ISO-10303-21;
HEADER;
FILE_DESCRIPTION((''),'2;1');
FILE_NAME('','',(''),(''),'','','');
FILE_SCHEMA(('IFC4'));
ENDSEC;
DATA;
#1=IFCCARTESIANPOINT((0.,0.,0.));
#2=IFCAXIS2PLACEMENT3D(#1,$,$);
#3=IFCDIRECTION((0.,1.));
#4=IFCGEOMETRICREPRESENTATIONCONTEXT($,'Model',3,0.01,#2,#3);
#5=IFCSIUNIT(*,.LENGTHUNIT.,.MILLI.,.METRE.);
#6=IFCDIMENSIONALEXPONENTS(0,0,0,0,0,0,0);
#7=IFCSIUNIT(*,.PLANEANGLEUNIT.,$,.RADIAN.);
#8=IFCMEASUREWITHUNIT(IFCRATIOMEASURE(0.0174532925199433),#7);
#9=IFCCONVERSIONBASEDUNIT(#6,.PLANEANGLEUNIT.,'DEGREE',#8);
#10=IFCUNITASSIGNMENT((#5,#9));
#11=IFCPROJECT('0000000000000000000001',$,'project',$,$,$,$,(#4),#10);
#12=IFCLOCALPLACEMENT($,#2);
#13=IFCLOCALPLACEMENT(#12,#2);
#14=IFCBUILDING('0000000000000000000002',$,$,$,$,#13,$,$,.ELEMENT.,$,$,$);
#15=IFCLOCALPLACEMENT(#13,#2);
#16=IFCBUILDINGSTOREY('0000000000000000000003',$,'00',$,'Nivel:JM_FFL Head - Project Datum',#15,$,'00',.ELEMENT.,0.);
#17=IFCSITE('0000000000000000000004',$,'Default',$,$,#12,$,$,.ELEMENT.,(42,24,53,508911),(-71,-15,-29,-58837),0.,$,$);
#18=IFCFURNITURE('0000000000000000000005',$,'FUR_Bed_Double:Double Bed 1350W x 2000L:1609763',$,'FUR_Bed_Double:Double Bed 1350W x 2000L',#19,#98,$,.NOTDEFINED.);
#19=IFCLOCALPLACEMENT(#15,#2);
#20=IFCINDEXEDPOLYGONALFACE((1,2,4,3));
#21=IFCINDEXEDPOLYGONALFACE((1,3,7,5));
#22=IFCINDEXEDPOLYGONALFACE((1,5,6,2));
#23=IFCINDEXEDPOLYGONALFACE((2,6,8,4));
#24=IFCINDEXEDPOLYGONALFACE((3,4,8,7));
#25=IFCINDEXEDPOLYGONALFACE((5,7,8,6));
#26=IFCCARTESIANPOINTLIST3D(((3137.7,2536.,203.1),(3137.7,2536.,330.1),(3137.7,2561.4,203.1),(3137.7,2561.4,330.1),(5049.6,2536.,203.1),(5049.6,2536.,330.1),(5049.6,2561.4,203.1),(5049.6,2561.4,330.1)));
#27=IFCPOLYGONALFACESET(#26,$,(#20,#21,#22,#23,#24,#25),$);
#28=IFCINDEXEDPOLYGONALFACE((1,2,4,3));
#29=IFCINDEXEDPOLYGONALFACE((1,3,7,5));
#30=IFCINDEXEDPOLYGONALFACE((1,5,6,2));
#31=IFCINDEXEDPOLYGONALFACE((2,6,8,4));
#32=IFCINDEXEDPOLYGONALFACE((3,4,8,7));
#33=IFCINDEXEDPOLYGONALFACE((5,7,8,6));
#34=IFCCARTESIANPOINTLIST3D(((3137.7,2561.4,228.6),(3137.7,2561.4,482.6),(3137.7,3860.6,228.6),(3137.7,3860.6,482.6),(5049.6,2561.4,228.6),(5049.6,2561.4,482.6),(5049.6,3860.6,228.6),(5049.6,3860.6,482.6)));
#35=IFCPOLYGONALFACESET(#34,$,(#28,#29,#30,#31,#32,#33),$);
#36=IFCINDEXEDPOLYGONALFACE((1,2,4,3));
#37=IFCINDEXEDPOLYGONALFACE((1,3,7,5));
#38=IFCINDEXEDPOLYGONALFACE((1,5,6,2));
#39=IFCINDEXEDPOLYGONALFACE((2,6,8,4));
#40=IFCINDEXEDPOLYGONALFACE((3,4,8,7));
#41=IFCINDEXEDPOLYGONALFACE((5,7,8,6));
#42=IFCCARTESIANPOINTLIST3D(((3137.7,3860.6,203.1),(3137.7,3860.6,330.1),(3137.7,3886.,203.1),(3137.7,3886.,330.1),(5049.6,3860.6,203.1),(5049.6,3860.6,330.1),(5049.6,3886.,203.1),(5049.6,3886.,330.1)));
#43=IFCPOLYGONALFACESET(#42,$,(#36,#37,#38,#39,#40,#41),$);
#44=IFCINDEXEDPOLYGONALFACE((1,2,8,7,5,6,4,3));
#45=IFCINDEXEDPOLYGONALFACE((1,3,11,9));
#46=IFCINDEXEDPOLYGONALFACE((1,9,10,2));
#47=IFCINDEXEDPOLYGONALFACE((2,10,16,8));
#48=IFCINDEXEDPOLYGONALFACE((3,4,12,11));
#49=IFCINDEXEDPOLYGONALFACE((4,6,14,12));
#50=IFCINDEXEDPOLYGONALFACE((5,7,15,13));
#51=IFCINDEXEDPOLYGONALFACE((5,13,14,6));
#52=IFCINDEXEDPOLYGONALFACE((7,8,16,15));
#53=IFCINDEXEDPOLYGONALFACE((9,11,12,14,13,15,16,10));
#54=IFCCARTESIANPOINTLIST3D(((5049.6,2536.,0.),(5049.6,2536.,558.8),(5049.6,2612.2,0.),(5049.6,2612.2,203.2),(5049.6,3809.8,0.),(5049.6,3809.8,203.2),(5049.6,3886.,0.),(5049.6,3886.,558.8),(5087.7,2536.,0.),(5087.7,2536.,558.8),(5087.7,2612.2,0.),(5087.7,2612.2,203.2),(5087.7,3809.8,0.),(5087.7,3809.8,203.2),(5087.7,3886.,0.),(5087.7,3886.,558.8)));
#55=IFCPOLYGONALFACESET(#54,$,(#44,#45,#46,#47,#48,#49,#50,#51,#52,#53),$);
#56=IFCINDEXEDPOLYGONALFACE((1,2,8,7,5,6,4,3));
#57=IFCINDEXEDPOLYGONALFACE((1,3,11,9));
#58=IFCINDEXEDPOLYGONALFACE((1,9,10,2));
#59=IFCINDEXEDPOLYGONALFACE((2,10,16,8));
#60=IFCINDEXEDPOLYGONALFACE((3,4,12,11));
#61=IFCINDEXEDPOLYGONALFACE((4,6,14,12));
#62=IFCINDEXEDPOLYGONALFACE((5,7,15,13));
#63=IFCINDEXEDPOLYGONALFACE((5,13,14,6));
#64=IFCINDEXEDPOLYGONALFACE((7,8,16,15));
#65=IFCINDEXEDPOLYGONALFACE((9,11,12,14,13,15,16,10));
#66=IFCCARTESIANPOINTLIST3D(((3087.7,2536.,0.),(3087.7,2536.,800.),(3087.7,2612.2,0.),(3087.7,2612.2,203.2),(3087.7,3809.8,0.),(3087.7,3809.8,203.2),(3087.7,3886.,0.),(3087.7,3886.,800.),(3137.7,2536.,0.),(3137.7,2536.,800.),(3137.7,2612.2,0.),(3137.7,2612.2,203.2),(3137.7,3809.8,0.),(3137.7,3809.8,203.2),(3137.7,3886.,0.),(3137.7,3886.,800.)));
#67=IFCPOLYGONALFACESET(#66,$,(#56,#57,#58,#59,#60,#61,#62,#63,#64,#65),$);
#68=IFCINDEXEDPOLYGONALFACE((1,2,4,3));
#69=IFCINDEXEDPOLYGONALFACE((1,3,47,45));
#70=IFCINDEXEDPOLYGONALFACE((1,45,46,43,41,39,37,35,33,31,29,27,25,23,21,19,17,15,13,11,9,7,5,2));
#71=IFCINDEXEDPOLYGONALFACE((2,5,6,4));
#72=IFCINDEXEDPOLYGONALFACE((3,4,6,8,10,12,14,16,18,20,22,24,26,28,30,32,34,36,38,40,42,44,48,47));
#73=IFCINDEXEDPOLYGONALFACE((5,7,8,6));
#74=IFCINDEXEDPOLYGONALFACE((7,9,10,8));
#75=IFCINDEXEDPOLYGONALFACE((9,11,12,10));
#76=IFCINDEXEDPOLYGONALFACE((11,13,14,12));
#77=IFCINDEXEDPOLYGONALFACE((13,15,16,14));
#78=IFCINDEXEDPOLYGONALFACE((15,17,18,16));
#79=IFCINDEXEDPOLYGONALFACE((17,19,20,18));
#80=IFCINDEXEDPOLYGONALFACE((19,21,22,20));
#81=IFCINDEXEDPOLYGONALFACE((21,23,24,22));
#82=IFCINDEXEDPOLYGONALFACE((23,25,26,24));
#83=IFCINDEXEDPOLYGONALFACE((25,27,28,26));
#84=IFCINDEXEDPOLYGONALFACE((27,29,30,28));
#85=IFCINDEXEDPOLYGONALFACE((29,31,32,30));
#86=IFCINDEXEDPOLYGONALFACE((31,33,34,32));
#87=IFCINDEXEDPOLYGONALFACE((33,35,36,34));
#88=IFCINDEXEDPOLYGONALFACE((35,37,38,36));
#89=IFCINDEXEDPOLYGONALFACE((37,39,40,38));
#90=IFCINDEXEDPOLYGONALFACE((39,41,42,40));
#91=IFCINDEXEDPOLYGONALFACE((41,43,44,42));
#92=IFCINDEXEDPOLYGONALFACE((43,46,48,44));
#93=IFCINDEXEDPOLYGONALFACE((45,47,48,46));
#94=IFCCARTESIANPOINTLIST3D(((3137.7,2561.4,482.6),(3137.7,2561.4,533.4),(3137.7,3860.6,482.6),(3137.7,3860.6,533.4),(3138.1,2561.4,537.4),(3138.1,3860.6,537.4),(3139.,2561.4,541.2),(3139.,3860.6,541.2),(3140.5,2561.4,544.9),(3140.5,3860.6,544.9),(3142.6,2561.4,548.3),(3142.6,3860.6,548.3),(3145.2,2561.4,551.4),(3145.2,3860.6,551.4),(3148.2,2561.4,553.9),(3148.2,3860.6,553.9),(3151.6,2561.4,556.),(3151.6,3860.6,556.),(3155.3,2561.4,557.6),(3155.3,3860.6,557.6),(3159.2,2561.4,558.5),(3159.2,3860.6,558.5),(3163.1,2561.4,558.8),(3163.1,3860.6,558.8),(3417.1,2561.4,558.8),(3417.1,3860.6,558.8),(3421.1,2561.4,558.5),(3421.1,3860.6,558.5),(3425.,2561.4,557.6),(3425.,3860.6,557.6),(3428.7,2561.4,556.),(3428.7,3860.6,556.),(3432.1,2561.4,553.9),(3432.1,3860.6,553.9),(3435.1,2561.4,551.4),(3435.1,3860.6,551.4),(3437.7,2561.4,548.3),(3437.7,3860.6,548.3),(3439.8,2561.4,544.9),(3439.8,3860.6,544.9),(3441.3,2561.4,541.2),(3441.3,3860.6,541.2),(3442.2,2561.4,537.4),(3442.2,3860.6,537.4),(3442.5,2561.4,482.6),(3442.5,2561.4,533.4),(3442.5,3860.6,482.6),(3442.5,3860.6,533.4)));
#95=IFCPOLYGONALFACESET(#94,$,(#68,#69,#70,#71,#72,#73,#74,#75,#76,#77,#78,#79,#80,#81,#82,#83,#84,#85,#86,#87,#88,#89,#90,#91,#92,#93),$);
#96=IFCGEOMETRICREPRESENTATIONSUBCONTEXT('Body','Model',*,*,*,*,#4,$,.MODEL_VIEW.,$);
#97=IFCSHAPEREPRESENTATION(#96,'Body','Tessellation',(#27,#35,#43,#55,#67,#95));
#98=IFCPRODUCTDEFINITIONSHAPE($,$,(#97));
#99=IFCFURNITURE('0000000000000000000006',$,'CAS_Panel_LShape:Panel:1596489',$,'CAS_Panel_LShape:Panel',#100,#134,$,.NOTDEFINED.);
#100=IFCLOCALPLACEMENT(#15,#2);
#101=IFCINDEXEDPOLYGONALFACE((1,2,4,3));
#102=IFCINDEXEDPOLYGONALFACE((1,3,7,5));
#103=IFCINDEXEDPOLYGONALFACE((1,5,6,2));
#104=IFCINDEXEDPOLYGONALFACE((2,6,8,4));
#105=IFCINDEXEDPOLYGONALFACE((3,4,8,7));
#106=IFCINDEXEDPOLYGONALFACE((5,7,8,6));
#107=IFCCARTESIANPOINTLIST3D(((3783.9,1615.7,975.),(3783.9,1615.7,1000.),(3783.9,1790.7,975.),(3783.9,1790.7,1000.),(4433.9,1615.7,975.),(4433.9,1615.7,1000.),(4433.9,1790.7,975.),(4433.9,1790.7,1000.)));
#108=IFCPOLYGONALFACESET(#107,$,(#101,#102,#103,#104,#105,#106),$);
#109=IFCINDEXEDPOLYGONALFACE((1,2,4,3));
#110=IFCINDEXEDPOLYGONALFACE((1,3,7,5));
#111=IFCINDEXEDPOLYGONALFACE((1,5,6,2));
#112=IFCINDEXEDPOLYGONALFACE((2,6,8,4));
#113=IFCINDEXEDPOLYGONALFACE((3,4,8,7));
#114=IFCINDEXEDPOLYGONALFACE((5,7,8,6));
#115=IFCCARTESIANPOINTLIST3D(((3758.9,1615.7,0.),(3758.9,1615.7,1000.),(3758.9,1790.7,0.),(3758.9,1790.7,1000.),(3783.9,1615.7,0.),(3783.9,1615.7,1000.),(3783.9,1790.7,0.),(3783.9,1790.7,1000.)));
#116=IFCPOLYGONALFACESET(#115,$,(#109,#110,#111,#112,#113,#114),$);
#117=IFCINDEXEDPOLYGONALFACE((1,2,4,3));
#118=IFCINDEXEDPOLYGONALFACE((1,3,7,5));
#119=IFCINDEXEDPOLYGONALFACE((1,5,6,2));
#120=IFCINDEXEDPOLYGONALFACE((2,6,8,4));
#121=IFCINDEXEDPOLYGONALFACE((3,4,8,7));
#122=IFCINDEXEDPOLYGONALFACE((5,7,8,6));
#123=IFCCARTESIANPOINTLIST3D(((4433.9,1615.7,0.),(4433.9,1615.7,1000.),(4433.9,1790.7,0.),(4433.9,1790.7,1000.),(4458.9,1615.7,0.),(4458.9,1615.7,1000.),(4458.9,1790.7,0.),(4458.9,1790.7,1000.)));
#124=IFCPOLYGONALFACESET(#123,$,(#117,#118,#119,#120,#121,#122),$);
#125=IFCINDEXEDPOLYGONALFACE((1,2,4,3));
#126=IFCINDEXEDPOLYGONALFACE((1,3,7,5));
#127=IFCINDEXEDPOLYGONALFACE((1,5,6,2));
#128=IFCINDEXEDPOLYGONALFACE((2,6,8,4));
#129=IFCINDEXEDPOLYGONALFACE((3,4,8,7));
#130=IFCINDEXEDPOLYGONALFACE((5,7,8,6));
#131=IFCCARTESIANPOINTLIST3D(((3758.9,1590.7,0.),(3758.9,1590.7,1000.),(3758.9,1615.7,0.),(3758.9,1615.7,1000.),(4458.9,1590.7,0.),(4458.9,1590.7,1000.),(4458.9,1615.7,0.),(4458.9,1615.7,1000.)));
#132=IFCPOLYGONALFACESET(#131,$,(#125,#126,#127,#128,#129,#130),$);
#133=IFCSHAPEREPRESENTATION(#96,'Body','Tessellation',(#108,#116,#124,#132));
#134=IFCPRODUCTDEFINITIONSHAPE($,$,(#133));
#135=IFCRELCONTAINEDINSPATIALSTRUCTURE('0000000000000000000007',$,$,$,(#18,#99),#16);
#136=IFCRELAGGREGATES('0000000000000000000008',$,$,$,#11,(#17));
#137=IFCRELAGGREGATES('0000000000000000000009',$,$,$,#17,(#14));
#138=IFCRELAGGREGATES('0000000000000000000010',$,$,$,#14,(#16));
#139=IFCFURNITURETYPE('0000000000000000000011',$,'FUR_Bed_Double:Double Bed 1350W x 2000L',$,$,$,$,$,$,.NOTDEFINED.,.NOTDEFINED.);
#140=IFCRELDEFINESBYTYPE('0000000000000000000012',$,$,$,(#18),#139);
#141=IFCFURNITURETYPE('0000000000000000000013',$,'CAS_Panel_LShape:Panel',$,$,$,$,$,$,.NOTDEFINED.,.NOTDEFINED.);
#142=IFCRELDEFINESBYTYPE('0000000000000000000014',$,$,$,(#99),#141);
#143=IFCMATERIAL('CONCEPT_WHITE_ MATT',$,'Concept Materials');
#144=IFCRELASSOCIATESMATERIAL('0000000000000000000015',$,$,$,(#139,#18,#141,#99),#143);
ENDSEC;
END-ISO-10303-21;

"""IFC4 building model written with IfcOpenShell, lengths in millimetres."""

from ifc_helpers import new_model, entity, si_unit, converted_unit, direction, frame, origin, place, context, subcontext, project, spatial, indexed_curve, outline, extrude, source, transform, mapped, material, type_object, type_shapes, element, save


model = new_model("IFC4")

# Units and contexts
model_context = context("Model", 3, precision=0.01, world=origin(), true_north=direction((0.0, 1.0)))
body_context = subcontext(model_context, "Body", "Model", "MODEL_VIEW")
ifc_project = project(units=[si_unit("LENGTHUNIT", "METRE", prefix="MILLI"), converted_unit("PLANEANGLEUNIT", "DEGREE", entity("IfcRatioMeasure", 0.0174532925199433), si_unit("PLANEANGLEUNIT", "RADIAN"), dimensions=[0, 0, 0, 0, 0, 0, 0])], contexts=[model_context])

# Site, building, storey
site_placement = place(None, origin())
site = spatial("IfcSite", under=ifc_project, at=site_placement, Name="Default", CompositionType="ELEMENT", RefLatitude=(42, 24, 53, 508911), RefLongitude=(-71, -15, -29, -58837), RefElevation=0.0)
building_placement = place(site_placement, origin())
building = spatial("IfcBuilding", under=site, at=building_placement, CompositionType="ELEMENT")
storey_placement = place(building_placement, origin())
storey = spatial("IfcBuildingStorey", under=building, at=storey_placement, Name="00", ObjectType="Nivel:JM_FFL Head - Project Datum", LongName="00", CompositionType="ELEMENT", Elevation=0.0)

# Shared definitions
ifc_material_1 = material(Name="CONCEPT_WHITE_ MATT", Category="Concept Materials")

# Furniture
furniture_type_1 = type_object("IfcFurnitureType", Name="FUR_Bed_Double:Double Bed 1350W x 2000L", AssemblyPlace="NOTDEFINED", PredefinedType="NOTDEFINED", material=ifc_material_1)
shared_shape_1 = source(origin(), body_context, "Body", "SweptSolid", [
    extrude(outline(indexed_curve([(-12.7, -956.0), (12.7, -956.0), (12.7, 956.0), (-12.7, 956.0), (-12.7, -956.0)], self_intersect=False)), frame((-681.4, -993.4, 203.1), z_axis=(0.0, 0.0, 1.0), x_axis=(-1.0, 0.0, 0.0)), (0.0, 0.0, 1.0), 127.0),
    extrude(outline(indexed_curve([(-649.6, -956.0), (649.6, -956.0), (649.6, 956.0), (-649.6, 956.0), (-649.6, -956.0)], self_intersect=False)), frame((-19.0, -993.5, 228.6), z_axis=(0.0, 0.0, 1.0), x_axis=(-1.0, 0.0, 0.0)), (0.0, 0.0, 1.0), 254.0),
    extrude(outline(indexed_curve([(-12.7, -956.0), (12.7, -956.0), (12.7, 956.0), (-12.7, 956.0), (-12.7, -956.0)], self_intersect=False)), frame((643.2, -993.4, 203.1)), (0.0, 0.0, 1.0), 127.0),
    extrude(outline(indexed_curve([(598.8, -190.5), (675.0, -190.5), (675.0, 368.3), (-675.0, 368.3), (-675.0, -190.5), (-598.8, -190.5), (-598.8, 12.7), (598.8, 12.7), (598.8, -190.5)], self_intersect=False)), frame((-19.1, -1987.5, 190.5), z_axis=(0.0, 1.0, 0.0), x_axis=(-1.0, 0.0, 0.0)), (0.0, 0.0, 1.0), 38.1),
    extrude(outline(indexed_curve([(-549.2, -675.0), (250.8, -675.0), (250.8, -598.8), (47.6, -598.8), (47.6, 598.8), (250.8, 598.8), (250.8, 675.0), (-549.2, 675.0), (-549.2, -675.0)], self_intersect=False)), frame((-19.1, -37.5, 250.8), z_axis=(0.0, 1.0, 0.0), x_axis=(0.0, 0.0, -1.0)), (0.0, 0.0, 1.0), 50.0),
    extrude(outline(indexed_curve([(152.4, 8.5), (152.1, 12.4), (151.2, 16.3), (149.6, 20.0), (147.5, 23.4), (145.0, 26.4), (141.9, 29.0), (138.5, 31.1), (134.8, 32.6), (131.0, 33.6), (127.0, 33.9), (-127.0, 33.9), (-131.0, 33.6), (-134.8, 32.6), (-138.5, 31.1), (-141.9, 29.0), (-145.0, 26.4), (-147.5, 23.4), (-149.6, 20.0), (-151.2, 16.3), (-152.1, 12.4), (-152.4, 8.5), (-152.4, -42.3), (152.4, -42.3), (152.4, 8.5)], self_intersect=False)), frame((-668.6, -189.9, 524.9), z_axis=(1.0, 0.0, 0.0), x_axis=(0.0, 1.0, 0.0)), (0.0, 0.0, 1.0), 1299.2),
])
type_shapes(furniture_type_1, [shared_shape_1])
for number, where, z_axis, x_axis, name in (
    (1, (3100.2, 3230.0, 0.0), (0.0, 0.0, 1.0), (0.0, 1.0, 0.0), "FUR_Bed_Double:Double Bed 1350W x 2000L:1609763"),
):
    element("IfcFurniture", number, at=place(storey_placement, frame(where, z_axis=z_axis, x_axis=x_axis)), inside=storey, type_object=furniture_type_1, material=ifc_material_1, Name=name, ObjectType="FUR_Bed_Double:Double Bed 1350W x 2000L", PredefinedType="NOTDEFINED", context=body_context, shape_type="MappedRepresentation", body=[
        mapped(shared_shape_1, transform((0.0, 0.0, 0.0), scale=1.0)),
    ])
furniture_type_2 = type_object("IfcFurnitureType", Name="CAS_Panel_LShape:Panel", AssemblyPlace="NOTDEFINED", PredefinedType="NOTDEFINED", material=ifc_material_1)
shared_shape_2 = source(origin(), body_context, "Body", "SweptSolid", [
    extrude(outline(indexed_curve([(-325.0, -87.5), (325.0, -87.5), (325.0, 87.5), (-325.0, 87.5), (-325.0, -87.5)], self_intersect=False)), frame((350.0, -112.5, 975.0)), (0.0, 0.0, 1.0), 25.0),
    extrude(outline(indexed_curve([(-12.5, -87.5), (12.5, -87.5), (12.5, 87.5), (-12.5, 87.5), (-12.5, -87.5)], self_intersect=False)), frame((687.5, -112.5, 0.0), z_axis=(0.0, 0.0, 1.0), x_axis=(-1.0, 0.0, 0.0)), (0.0, 0.0, 1.0), 1000.0),
    extrude(outline(indexed_curve([(-87.5, -12.5), (87.5, -12.5), (87.5, 12.5), (-87.5, 12.5), (-87.5, -12.5)], self_intersect=False)), frame((12.5, -112.5, 0.0), z_axis=(0.0, 0.0, 1.0), x_axis=(0.0, -1.0, 0.0)), (0.0, 0.0, 1.0), 1000.0),
    extrude(outline(indexed_curve([(-12.5, -350.0), (12.5, -350.0), (12.5, 350.0), (-12.5, 350.0), (-12.5, -350.0)], self_intersect=False)), frame((350.0, -12.5, 0.0), z_axis=(0.0, 0.0, 1.0), x_axis=(0.0, -1.0, 0.0)), (0.0, 0.0, 1.0), 1000.0),
])
type_shapes(furniture_type_2, [shared_shape_2])
furniture_1_placement = place(storey_placement, frame((4458.9, 1590.7, 0.0), z_axis=(0.0, 0.0, 1.0), x_axis=(-1.0, 0.0, 0.0)))
element("IfcFurniture", 2, at=furniture_1_placement, inside=storey, type_object=furniture_type_2, material=ifc_material_1, Name="CAS_Panel_LShape:Panel:1596489", ObjectType="CAS_Panel_LShape:Panel", PredefinedType="NOTDEFINED", context=body_context, shape_type="MappedRepresentation", body=[
    mapped(shared_shape_2, transform((0.0, 0.0, 0.0), scale=1.0)),
])

save(model, "model.ifc")
